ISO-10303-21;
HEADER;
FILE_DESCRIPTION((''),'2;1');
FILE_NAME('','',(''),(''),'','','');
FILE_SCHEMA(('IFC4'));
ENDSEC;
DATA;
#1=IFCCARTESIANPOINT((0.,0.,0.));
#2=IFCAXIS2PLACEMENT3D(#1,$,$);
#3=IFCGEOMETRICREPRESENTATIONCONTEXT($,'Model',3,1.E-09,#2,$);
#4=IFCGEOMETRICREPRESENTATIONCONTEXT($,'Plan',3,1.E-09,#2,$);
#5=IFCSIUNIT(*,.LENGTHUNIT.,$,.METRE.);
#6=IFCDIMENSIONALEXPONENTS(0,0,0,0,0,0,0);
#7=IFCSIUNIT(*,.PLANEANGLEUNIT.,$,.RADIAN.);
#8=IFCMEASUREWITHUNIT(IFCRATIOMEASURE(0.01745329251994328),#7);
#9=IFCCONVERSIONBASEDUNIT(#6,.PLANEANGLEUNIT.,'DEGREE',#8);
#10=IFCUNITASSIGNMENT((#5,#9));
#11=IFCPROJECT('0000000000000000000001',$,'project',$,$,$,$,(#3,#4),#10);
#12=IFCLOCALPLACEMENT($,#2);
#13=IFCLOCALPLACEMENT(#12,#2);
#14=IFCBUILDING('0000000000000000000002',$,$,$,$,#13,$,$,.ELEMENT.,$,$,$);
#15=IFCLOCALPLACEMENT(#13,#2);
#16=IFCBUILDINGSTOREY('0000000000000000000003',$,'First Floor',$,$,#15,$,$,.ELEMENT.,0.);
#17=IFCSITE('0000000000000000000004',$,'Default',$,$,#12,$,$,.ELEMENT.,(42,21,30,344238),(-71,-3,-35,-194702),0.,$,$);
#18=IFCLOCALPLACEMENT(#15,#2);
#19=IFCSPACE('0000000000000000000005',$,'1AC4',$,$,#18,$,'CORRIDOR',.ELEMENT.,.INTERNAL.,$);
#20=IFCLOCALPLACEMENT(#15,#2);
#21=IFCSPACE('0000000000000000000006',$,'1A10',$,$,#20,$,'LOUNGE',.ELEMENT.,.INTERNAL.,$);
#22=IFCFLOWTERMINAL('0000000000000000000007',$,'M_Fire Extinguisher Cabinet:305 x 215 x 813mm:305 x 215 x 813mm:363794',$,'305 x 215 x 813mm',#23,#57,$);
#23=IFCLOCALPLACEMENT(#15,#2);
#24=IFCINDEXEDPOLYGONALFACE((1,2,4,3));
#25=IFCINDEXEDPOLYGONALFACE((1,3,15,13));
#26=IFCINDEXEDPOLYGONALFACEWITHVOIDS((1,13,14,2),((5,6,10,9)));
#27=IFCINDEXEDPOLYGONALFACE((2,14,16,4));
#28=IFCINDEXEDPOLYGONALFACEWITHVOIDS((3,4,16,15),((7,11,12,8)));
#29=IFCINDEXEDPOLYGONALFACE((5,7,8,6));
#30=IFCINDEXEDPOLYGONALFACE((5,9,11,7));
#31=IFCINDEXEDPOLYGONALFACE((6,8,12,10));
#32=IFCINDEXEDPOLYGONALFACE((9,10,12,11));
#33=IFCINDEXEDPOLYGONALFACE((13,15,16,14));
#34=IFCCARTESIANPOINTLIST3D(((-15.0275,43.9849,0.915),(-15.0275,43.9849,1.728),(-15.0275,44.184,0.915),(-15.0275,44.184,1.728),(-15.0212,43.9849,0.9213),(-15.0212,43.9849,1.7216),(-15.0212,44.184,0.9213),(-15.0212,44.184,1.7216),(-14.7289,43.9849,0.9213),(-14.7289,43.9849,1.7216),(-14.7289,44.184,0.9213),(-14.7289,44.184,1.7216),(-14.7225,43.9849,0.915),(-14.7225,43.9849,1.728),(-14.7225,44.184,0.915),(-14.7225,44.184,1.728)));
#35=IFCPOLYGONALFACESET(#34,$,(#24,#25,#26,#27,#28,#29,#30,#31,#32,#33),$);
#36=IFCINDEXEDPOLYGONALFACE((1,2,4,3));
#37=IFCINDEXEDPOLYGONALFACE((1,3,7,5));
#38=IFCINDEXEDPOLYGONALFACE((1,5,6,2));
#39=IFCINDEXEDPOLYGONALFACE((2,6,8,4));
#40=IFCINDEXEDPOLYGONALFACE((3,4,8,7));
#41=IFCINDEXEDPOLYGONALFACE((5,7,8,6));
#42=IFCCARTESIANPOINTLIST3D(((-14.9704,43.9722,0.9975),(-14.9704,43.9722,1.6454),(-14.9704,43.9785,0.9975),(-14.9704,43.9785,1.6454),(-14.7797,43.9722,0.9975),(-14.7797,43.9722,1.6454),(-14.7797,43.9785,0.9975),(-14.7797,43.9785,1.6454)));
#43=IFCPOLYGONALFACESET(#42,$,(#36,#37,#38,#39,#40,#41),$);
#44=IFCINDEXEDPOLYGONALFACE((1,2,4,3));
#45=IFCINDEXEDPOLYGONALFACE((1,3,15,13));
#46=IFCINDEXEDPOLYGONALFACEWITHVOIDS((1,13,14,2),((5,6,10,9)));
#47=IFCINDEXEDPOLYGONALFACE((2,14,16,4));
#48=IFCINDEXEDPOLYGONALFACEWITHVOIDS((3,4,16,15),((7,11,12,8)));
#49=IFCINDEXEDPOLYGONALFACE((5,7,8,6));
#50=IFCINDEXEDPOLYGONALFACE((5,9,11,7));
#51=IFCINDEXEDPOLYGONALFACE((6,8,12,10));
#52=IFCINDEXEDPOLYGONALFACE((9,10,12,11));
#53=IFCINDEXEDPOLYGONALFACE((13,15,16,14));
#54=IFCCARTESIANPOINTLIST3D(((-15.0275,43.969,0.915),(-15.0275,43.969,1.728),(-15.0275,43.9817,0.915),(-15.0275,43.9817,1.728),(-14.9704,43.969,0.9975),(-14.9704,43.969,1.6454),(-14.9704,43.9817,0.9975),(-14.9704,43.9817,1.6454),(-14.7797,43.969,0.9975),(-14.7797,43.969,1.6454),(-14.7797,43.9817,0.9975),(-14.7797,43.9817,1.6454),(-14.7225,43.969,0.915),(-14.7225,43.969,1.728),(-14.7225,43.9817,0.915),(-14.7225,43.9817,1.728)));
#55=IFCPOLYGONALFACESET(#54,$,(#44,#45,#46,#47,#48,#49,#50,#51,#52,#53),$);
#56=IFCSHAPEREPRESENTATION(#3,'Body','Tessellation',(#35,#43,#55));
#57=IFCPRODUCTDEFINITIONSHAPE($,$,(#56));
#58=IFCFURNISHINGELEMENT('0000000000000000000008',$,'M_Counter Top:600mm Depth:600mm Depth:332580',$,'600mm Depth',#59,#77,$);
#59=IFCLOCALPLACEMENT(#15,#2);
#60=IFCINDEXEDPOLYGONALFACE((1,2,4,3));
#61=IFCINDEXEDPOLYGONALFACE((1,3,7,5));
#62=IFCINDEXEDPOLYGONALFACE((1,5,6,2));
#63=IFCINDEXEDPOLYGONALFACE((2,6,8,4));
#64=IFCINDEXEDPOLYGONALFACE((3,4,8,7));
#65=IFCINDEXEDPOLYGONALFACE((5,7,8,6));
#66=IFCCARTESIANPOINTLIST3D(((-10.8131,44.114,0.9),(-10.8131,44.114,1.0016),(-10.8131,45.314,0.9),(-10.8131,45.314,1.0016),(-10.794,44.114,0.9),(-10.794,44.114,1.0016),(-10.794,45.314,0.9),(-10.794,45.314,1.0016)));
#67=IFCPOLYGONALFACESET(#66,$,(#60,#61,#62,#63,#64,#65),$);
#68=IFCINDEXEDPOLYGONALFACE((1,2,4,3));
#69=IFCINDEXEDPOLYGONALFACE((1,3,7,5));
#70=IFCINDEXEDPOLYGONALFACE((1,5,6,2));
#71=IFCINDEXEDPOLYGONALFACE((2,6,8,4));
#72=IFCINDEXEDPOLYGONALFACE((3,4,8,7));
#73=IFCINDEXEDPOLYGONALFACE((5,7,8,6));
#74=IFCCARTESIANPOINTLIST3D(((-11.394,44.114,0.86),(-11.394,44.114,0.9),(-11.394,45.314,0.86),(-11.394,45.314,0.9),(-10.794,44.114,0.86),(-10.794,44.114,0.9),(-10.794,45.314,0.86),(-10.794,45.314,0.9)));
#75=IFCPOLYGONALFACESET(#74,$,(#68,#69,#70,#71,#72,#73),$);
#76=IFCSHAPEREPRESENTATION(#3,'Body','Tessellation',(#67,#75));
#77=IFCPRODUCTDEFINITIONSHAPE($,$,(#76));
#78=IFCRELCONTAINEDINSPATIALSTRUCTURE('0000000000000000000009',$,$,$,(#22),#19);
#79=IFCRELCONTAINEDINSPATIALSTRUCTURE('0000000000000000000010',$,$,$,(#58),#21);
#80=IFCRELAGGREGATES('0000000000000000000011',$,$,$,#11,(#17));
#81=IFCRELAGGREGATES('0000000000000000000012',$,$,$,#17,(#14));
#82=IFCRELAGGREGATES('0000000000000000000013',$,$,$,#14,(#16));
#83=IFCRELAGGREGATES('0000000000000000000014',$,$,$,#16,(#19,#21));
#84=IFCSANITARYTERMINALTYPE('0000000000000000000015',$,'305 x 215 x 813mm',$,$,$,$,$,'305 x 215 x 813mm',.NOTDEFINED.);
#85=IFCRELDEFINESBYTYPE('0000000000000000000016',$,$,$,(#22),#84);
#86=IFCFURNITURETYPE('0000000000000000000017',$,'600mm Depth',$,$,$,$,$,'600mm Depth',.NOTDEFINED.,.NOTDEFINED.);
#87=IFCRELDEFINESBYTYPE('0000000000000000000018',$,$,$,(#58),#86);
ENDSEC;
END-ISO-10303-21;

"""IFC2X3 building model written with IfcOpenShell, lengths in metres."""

from ifc_helpers import new_model, entity, si_unit, converted_unit, frame, origin, origin_2d_with_axis, place, context, project, spatial, polyline, rectangle, outline, extrude, source, transform, mapped, type_object, type_shapes, element, save


model = new_model("IFC2X3")

# Units and contexts
model_context = context("Model", 3, precision=1e-09, world=origin())
plan_context = context("Plan", 3, precision=1e-09, world=origin())
ifc_project = project(units=[si_unit("LENGTHUNIT", "METRE"), converted_unit("PLANEANGLEUNIT", "DEGREE", entity("IfcRatioMeasure", 0.01745329251994328), si_unit("PLANEANGLEUNIT", "RADIAN"), dimensions=[0, 0, 0, 0, 0, 0, 0])], contexts=[model_context, plan_context])

# Site, building, storey
site_placement = place(None, origin())
site = spatial("IfcSite", under=ifc_project, at=site_placement, Name="Default", CompositionType="ELEMENT", RefLatitude=(42, 21, 30, 344238), RefLongitude=(-71, -3, -35, -194702), RefElevation=0.0)
building_placement = place(site_placement, origin())
building = spatial("IfcBuilding", under=site, at=building_placement, CompositionType="ELEMENT")
storey_placement = place(building_placement, origin())
storey = spatial("IfcBuildingStorey", under=building, at=storey_placement, Name="First Floor", CompositionType="ELEMENT", Elevation=0.0)

# Shared definitions
space_1_placement = place(storey_placement, origin())
space_1 = spatial("IfcSpace", under=storey, at=space_1_placement, Name="1AC4", LongName="CORRIDOR", CompositionType="ELEMENT", InteriorOrExteriorSpace="INTERNAL")

# Flow terminal
sanitary_terminal_type_1 = type_object("IfcSanitaryTerminalType", Name="305 x 215 x 813mm", ElementType="305 x 215 x 813mm", PredefinedType="NOTDEFINED")
shared_shape_1 = source(origin(), model_context, "Body", "SweptSolid", [
    extrude(outline(polyline([(-0.1525, -0.4065), (0.1525, -0.4065), (0.1525, 0.4065), (-0.1525, 0.4065), (-0.1525, -0.4065)]), holes=[polyline([(-0.1462, -0.4001), (-0.1462, 0.4002), (0.1462, 0.4002), (0.1462, -0.4001), (-0.1462, -0.4001)])]), frame((-0.1096, 0.027, 1.3215), z_axis=(0.0, 1.0, 0.0), x_axis=(1.0, 0.0, 0.0)), (0.0, 0.0, 1.0), 0.1991),
    extrude(rectangle(XDim=0.0064, YDim=0.1907, at=origin_2d_with_axis()), frame((-0.1096, 0.2356, 0.9975), z_axis=(0.0, 0.0, 1.0), x_axis=(0.0, -1.0, 0.0)), (0.0, 0.0, 1.0), 0.6479),
    extrude(outline(polyline([(-0.1525, -0.4065), (0.1525, -0.4065), (0.1525, 0.4065), (-0.1525, 0.4065), (-0.1525, -0.4065)]), holes=[polyline([(-0.0953, -0.3239), (-0.0953, 0.324), (0.0954, 0.324), (0.0954, -0.3239), (-0.0953, -0.3239)])]), frame((-0.1096, 0.2293, 1.3215), z_axis=(0.0, 1.0, 0.0), x_axis=(1.0, 0.0, 0.0)), (0.0, 0.0, 1.0), 0.0127),
])
type_shapes(sanitary_terminal_type_1, [shared_shape_1])
flow_terminal_1_placement = place(space_1_placement, frame((-14.9846, 44.211, 0.0), z_axis=(0.0, 0.0, 1.0), x_axis=(-1.0, 0.0, 0.0)))
element("IfcFlowTerminal", 1, at=flow_terminal_1_placement, inside=space_1, type_object=sanitary_terminal_type_1, Name="M_Fire Extinguisher Cabinet:305 x 215 x 813mm:305 x 215 x 813mm:363794", ObjectType="305 x 215 x 813mm", context=model_context, shape_type="MappedRepresentation", body=[
    mapped(shared_shape_1, transform((0.0, 0.0, 0.0), scale=1.0)),
])

# Shared definitions
space_2_placement = place(storey_placement, origin())
space_2 = spatial("IfcSpace", under=storey, at=space_2_placement, Name="1A10", LongName="LOUNGE", CompositionType="ELEMENT", InteriorOrExteriorSpace="INTERNAL")

# Furnishing element
furniture_type = type_object("IfcFurnitureType", Name="600mm Depth", ElementType="600mm Depth", AssemblyPlace="NOTDEFINED")
shared_shape_2 = source(origin(), model_context, "Body", "SweptSolid", [
    extrude(rectangle(XDim=0.0191, YDim=1.2, at=origin_2d_with_axis()), frame((-0.6005, -0.0095, 0.9), z_axis=(0.0, 0.0, 1.0), x_axis=(0.0, -1.0, 0.0)), (0.0, 0.0, 1.0), 0.1016),
    extrude(rectangle(XDim=1.2, YDim=0.6, at=origin_2d_with_axis()), frame((-0.6005, -0.3, 0.86), z_axis=(0.0, 0.0, 1.0), x_axis=(-1.0, 0.0, 0.0)), (0.0, 0.0, 1.0), 0.04),
])
type_shapes(furniture_type, [shared_shape_2])
furnishing_placement = place(space_2_placement, frame((-10.794, 44.1135, 0.0), z_axis=(0.0, 0.0, 1.0), x_axis=(0.0, -1.0, 0.0)))
element("IfcFurnishingElement", 2, at=furnishing_placement, inside=space_2, type_object=furniture_type, Name="M_Counter Top:600mm Depth:600mm Depth:332580", ObjectType="600mm Depth", context=model_context, shape_type="MappedRepresentation", body=[
    mapped(shared_shape_2, transform((0.0, 0.0, 0.0), scale=1.0)),
])

save(model, "model.ifc")
